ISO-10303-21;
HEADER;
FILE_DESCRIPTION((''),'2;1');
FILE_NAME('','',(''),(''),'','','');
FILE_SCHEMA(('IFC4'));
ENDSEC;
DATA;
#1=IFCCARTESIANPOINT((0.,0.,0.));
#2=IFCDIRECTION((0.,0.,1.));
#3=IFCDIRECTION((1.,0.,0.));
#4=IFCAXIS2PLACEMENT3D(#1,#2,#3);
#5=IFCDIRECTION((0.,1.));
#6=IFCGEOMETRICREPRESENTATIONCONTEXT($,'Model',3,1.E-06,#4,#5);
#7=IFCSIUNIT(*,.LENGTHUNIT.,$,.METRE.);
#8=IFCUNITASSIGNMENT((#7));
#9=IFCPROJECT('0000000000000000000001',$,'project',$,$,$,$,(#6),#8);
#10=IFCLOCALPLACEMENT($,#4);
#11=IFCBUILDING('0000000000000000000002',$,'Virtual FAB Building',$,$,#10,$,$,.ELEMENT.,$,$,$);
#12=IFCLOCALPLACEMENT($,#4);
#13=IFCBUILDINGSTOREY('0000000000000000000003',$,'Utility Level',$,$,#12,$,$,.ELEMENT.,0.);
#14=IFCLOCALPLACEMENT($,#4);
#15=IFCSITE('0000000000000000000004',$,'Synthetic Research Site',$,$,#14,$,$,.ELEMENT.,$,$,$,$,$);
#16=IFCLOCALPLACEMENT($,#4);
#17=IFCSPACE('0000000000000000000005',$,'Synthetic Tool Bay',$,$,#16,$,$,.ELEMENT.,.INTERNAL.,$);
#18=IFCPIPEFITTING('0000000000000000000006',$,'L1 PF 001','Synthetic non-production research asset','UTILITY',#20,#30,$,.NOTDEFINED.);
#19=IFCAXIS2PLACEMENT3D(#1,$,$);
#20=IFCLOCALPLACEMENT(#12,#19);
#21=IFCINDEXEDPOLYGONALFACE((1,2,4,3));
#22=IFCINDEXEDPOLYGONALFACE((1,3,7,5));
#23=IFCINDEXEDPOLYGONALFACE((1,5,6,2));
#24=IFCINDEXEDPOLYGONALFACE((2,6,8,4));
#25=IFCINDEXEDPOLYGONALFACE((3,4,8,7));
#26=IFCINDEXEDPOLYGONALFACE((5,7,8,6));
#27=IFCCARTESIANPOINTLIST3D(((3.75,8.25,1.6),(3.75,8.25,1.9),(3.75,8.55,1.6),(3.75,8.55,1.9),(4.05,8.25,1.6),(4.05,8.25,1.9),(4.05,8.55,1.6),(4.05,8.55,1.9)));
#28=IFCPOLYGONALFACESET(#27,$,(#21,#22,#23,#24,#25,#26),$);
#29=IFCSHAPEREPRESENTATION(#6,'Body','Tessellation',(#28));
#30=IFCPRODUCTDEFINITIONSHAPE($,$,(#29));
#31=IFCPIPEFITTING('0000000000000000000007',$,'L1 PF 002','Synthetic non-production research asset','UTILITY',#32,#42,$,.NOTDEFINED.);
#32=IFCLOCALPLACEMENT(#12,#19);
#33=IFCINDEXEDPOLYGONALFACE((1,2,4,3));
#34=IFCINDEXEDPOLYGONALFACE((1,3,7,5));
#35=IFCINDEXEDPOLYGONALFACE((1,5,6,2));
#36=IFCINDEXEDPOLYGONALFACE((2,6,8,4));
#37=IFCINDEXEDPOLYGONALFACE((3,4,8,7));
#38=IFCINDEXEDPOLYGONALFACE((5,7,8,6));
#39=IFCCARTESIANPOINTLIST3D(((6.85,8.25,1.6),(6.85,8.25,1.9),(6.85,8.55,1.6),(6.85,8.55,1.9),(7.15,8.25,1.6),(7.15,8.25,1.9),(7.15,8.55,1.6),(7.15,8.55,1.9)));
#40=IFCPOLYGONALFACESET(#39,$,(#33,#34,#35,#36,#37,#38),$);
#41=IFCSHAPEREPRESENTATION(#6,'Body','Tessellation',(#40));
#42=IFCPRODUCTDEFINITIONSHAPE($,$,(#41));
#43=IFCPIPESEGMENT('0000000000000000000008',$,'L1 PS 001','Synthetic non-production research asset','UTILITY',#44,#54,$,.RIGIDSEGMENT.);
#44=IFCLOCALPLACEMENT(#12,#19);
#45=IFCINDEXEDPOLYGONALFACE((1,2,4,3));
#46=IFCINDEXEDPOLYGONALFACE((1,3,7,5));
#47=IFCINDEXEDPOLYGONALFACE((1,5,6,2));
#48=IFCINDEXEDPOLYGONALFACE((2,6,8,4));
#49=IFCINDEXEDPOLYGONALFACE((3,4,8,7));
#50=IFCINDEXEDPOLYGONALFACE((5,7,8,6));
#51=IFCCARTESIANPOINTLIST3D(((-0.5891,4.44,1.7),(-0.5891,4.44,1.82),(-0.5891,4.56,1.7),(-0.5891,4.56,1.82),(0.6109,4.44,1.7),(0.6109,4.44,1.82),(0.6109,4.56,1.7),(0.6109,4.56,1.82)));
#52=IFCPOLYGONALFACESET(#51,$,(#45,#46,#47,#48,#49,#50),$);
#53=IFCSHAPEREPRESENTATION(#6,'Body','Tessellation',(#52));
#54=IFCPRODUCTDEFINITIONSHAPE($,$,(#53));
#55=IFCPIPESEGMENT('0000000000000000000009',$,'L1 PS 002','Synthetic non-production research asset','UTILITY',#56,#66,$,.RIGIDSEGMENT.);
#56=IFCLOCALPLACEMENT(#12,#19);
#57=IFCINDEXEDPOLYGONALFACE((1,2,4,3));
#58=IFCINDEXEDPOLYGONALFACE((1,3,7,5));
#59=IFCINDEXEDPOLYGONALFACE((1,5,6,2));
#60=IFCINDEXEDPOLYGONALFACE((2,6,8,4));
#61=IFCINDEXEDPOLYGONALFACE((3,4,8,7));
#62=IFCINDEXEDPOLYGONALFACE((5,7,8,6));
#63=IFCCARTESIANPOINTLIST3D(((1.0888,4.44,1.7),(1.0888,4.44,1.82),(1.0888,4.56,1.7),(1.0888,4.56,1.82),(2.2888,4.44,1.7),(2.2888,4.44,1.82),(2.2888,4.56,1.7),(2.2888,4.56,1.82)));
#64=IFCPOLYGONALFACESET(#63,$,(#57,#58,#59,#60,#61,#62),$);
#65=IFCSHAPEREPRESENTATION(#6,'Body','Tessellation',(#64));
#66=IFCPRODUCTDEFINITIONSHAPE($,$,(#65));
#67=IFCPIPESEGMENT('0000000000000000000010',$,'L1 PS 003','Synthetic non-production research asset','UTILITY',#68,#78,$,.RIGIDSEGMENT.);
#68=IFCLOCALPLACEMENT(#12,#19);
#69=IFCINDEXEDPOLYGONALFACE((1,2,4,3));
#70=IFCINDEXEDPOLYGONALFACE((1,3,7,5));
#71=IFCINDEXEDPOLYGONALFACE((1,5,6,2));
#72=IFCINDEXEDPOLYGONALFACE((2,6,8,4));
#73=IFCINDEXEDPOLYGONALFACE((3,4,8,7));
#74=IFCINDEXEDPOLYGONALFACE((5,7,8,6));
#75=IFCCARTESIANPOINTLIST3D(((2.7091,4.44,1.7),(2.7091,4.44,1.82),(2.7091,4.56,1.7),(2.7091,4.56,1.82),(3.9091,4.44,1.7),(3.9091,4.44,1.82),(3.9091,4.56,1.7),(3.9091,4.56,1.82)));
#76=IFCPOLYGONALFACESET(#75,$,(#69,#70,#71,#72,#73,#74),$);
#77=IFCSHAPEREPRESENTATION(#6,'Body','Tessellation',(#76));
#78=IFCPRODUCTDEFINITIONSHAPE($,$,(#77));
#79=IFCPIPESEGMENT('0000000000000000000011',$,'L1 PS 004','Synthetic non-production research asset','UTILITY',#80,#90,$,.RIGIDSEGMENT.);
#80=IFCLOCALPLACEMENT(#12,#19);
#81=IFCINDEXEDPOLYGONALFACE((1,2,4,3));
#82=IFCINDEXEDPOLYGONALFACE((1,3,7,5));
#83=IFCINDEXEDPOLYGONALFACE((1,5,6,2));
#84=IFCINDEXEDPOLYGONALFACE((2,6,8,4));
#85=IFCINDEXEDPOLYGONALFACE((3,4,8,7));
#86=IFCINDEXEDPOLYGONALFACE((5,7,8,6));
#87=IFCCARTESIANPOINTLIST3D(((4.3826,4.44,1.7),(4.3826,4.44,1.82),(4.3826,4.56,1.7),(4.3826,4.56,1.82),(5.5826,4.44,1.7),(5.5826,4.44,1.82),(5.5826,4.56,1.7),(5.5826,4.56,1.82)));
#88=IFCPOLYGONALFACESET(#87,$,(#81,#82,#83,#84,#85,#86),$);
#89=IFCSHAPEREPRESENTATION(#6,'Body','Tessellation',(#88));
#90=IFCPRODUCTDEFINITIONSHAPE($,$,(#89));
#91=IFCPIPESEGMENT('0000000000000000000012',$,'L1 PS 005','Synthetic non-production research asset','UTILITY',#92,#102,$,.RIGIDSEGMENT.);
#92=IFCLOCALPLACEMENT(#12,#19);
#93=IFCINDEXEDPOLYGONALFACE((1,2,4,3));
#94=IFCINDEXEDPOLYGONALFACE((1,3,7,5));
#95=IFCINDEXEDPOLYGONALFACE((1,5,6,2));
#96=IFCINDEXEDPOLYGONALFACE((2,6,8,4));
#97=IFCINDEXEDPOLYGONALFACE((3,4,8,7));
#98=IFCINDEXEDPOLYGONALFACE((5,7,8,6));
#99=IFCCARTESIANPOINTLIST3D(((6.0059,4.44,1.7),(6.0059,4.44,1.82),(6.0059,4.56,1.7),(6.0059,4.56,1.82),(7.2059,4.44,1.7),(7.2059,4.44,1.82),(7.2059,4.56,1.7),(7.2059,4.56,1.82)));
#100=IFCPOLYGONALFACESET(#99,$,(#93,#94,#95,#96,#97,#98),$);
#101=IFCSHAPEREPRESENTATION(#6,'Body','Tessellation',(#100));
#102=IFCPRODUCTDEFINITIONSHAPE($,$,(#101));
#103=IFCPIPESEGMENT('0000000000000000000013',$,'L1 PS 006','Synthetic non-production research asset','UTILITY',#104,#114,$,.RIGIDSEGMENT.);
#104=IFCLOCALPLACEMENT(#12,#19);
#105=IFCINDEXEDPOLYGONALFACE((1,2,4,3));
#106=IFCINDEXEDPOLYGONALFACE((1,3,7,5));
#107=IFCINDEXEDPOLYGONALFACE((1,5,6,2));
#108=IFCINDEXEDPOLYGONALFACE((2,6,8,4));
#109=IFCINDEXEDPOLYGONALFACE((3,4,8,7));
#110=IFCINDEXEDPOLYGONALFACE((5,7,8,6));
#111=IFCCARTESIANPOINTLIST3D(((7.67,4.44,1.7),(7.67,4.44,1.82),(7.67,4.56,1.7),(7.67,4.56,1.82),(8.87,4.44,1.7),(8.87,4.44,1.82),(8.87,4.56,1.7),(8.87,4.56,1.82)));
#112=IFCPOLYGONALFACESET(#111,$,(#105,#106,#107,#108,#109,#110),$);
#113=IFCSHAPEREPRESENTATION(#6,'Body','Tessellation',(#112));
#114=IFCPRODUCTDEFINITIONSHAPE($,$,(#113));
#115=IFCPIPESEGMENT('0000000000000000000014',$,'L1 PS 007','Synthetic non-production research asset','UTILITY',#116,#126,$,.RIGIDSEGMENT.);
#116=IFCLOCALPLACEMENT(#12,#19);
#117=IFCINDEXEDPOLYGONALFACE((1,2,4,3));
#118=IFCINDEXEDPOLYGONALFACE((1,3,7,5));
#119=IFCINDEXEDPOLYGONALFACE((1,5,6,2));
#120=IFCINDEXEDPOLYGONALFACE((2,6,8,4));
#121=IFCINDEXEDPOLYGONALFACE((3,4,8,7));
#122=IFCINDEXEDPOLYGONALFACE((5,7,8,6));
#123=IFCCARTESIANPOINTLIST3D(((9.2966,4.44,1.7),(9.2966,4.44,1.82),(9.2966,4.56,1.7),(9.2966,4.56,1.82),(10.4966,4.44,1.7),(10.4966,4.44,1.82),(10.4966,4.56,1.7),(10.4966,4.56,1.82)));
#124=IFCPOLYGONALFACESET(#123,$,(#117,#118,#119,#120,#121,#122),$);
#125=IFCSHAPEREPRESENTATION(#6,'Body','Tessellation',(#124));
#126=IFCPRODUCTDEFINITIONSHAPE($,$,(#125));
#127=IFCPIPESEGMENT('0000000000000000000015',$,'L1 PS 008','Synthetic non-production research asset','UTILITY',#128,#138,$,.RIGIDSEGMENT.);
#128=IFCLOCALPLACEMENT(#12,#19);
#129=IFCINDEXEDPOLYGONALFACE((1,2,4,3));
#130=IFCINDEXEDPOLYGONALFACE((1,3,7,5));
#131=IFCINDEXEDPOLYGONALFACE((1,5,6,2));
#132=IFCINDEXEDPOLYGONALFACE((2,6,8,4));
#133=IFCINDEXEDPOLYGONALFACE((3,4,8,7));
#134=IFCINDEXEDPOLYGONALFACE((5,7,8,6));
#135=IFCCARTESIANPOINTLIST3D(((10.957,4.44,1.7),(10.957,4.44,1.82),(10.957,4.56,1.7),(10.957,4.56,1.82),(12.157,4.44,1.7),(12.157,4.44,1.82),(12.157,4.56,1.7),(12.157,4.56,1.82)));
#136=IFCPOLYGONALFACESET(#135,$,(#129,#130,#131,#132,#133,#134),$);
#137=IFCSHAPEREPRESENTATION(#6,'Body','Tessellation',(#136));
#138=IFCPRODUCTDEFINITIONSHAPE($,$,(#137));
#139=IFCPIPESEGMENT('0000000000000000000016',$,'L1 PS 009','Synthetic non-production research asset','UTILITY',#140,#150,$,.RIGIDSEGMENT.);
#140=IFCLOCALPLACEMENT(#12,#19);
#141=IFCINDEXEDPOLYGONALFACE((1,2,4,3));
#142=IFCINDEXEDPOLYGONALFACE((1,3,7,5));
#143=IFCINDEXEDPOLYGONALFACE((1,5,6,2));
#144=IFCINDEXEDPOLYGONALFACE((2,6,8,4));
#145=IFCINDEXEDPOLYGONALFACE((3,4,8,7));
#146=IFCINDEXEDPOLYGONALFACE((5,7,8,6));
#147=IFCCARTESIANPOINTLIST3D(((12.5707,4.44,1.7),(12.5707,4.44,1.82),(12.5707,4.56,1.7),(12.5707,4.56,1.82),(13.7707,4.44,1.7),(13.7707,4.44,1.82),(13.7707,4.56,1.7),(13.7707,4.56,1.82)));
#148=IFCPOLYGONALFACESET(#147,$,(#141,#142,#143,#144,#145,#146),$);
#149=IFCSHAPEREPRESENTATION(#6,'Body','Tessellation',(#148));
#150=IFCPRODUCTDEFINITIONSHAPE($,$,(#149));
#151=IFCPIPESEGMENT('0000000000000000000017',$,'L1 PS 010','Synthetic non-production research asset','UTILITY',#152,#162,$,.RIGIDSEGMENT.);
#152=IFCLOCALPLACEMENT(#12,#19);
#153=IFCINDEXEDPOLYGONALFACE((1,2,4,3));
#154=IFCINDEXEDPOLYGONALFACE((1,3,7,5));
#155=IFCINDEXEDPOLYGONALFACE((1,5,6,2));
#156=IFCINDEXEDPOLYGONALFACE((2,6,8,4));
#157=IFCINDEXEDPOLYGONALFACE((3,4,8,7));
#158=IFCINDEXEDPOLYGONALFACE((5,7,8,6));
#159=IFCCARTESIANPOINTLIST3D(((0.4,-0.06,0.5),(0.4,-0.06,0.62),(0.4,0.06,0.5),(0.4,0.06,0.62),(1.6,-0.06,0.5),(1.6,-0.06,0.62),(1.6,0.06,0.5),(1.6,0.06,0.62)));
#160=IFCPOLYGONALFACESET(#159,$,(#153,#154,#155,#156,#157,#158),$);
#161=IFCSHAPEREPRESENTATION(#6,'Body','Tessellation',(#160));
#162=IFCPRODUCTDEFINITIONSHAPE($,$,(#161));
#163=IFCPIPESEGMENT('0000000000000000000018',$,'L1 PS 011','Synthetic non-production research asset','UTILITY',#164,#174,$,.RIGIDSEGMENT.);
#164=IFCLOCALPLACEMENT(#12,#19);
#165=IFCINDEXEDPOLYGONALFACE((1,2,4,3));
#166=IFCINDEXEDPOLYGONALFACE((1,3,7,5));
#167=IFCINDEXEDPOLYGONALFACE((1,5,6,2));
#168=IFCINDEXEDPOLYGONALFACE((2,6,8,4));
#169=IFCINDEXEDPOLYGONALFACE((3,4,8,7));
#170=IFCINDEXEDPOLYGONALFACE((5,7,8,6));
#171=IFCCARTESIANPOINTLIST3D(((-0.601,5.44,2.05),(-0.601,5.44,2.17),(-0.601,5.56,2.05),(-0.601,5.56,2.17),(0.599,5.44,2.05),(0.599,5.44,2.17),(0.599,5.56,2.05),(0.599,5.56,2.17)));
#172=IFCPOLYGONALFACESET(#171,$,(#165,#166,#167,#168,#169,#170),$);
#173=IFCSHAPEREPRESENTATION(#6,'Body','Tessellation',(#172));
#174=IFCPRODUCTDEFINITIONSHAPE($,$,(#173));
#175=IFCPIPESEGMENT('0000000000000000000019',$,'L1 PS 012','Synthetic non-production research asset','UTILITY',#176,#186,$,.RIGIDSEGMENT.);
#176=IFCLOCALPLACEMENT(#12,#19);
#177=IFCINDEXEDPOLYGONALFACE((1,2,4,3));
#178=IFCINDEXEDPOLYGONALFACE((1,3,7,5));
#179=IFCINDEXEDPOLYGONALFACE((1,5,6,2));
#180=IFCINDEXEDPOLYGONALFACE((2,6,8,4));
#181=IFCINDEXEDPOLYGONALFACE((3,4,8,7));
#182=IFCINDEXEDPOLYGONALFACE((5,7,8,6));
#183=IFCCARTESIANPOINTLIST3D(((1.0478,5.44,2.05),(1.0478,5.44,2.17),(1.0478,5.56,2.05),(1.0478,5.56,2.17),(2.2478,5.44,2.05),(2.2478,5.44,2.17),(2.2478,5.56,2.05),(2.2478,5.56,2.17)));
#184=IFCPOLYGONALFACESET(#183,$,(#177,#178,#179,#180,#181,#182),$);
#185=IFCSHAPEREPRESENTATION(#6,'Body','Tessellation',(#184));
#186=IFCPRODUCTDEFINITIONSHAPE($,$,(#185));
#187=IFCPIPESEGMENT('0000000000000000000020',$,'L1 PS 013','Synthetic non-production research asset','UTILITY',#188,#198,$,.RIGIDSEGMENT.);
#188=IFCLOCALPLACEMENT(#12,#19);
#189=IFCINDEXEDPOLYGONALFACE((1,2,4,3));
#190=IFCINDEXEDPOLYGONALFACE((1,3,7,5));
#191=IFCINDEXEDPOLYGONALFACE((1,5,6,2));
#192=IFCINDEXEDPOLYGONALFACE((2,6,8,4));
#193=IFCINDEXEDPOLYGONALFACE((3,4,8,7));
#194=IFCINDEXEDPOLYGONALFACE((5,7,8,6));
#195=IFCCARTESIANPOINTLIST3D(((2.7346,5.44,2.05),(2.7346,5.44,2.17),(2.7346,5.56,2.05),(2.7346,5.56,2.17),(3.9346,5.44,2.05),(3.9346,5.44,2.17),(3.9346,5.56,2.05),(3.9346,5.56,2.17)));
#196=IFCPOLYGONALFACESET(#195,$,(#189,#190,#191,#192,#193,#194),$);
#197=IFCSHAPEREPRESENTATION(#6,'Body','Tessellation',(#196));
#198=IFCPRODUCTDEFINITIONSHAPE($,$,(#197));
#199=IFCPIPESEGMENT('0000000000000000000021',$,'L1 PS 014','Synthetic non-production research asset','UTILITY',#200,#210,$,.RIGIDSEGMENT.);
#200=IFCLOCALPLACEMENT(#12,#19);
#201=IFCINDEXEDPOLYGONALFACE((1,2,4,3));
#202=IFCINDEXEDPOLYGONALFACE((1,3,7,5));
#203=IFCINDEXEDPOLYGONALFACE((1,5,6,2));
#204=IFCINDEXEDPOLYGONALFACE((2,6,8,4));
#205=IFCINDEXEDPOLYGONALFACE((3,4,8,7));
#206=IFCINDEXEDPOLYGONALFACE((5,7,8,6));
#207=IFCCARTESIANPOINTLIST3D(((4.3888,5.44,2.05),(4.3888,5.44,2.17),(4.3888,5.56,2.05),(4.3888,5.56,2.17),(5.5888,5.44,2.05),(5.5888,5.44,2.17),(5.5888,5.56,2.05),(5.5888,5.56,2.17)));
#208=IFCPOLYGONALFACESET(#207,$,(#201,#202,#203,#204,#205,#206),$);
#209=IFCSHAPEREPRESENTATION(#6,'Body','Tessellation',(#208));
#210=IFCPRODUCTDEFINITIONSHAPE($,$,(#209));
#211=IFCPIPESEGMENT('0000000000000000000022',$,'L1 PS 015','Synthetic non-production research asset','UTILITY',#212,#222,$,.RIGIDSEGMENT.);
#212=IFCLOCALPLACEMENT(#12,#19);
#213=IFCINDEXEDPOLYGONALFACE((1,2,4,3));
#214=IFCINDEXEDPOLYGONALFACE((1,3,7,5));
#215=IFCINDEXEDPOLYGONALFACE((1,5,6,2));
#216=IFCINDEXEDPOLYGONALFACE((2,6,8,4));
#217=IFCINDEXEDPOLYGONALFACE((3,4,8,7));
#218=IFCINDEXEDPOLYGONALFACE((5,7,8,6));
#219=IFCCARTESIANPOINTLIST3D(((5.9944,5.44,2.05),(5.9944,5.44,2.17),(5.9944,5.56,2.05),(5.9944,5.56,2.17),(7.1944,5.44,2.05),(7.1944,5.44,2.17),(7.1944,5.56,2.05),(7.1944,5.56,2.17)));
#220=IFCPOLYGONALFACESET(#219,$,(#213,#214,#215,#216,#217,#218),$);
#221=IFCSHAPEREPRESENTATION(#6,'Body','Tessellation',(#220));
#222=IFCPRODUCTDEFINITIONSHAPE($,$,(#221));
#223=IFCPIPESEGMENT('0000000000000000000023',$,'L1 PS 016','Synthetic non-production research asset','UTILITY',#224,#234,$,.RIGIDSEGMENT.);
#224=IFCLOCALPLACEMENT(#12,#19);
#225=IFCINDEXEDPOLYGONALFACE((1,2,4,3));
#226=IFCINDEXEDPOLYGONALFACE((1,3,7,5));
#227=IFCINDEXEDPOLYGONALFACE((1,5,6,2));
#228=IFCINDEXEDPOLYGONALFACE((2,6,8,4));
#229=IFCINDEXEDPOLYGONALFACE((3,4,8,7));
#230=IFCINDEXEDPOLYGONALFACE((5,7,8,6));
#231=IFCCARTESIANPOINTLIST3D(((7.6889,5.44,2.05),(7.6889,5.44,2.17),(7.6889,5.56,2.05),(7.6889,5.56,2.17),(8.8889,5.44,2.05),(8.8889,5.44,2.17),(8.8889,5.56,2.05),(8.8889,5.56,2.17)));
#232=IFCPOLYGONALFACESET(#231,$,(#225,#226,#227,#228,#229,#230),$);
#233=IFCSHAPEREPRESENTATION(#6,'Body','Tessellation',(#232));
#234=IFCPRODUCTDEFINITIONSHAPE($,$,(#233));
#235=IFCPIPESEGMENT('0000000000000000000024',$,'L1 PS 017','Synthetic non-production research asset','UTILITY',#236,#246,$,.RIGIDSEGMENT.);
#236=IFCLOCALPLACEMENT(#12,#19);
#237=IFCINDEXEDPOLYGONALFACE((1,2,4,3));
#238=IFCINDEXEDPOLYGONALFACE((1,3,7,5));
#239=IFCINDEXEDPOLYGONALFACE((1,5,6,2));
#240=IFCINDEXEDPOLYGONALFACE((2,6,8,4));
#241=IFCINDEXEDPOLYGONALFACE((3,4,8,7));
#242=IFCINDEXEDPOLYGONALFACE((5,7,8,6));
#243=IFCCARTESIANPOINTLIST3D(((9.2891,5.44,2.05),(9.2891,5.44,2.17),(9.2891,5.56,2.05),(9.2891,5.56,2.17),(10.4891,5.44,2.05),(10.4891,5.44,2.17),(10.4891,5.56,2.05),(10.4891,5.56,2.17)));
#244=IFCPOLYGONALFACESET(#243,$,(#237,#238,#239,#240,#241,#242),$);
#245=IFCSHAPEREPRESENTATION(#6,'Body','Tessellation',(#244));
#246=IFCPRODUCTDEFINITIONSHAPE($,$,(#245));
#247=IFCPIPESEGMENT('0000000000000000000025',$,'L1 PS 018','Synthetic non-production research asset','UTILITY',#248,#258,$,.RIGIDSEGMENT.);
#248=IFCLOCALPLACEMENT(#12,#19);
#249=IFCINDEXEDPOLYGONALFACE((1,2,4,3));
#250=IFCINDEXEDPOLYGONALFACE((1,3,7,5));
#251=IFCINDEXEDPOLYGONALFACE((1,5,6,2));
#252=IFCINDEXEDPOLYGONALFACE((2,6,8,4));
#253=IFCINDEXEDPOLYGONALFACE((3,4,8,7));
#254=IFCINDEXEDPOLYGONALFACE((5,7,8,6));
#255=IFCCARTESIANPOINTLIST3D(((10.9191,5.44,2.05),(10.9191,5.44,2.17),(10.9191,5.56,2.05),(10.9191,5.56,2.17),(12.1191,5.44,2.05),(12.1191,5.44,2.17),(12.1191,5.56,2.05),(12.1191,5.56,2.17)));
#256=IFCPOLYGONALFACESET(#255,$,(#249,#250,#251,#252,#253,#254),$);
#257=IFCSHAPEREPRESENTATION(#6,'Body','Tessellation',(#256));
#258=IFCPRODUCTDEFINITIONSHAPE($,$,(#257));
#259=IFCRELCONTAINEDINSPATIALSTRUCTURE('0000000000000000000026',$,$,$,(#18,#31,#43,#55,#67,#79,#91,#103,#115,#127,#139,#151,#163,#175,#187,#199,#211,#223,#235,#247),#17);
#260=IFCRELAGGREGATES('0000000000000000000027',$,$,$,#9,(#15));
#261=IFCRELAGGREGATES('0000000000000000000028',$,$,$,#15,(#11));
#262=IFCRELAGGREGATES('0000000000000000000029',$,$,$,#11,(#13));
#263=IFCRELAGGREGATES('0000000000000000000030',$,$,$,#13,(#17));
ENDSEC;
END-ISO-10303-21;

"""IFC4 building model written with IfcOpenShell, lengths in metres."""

from ifc_helpers import new_model, si_unit, direction, frame, origin_with_axes, origin_2d_with_axis, place, context, project, spatial, rectangle, extrude, element, save


model = new_model("IFC4")

# Units and contexts
model_context = context("Model", 3, precision=1e-06, world=origin_with_axes(), true_north=direction((0.0, 1.0)))
ifc_project = project(units=[si_unit("LENGTHUNIT", "METRE")], contexts=[model_context])

# Site, building, storey, space
site_placement = place(None, origin_with_axes())
site = spatial("IfcSite", under=ifc_project, at=site_placement, Name="Synthetic Research Site", CompositionType="ELEMENT")
building_placement = place(None, origin_with_axes())
building = spatial("IfcBuilding", under=site, at=building_placement, Name="Virtual FAB Building", CompositionType="ELEMENT")
storey_placement = place(None, origin_with_axes())
storey = spatial("IfcBuildingStorey", under=building, at=storey_placement, Name="Utility Level", CompositionType="ELEMENT", Elevation=0.0)
space_placement = place(None, origin_with_axes())
space = spatial("IfcSpace", under=storey, at=space_placement, Name="Synthetic Tool Bay", CompositionType="ELEMENT", PredefinedType="INTERNAL")

# Pipe fittings
for number, where, z_axis, x_axis, name in (
    (1, (3.9, 8.4, 1.6), (0.0, 0.0, 1.0), (1.0, 0.0, 0.0), "L1 PF 001"),
    (2, (7.0, 8.4, 1.6), (0.0, 0.0, 1.0), (1.0, 0.0, 0.0), "L1 PF 002"),
):
    element("IfcPipeFitting", number, at=place(None, frame(where, z_axis=z_axis, x_axis=x_axis)), inside=space, Name=name, Description="Synthetic non-production research asset", ObjectType="UTILITY", PredefinedType="NOTDEFINED", context=model_context, shape_type="SweptSolid", body=[
        extrude(rectangle(XDim=0.3, YDim=0.3, at=origin_2d_with_axis()), origin_with_axes(), (0.0, 0.0, 1.0), 0.3),
    ])

# Pipe segments
for number, where, z_axis, x_axis, name in (
    (3, (0.0109, 4.5, 1.7), (0.0, 0.0, 1.0), (1.0, 0.0, 0.0), "L1 PS 001"),
    (4, (1.6888, 4.5, 1.7), (0.0, 0.0, 1.0), (1.0, 0.0, 0.0), "L1 PS 002"),
    (5, (3.3091, 4.5, 1.7), (0.0, 0.0, 1.0), (1.0, 0.0, 0.0), "L1 PS 003"),
    (6, (4.9826, 4.5, 1.7), (0.0, 0.0, 1.0), (1.0, 0.0, 0.0), "L1 PS 004"),
    (7, (6.6059, 4.5, 1.7), (0.0, 0.0, 1.0), (1.0, 0.0, 0.0), "L1 PS 005"),
    (8, (8.27, 4.5, 1.7), (0.0, 0.0, 1.0), (1.0, 0.0, 0.0), "L1 PS 006"),
    (9, (9.8966, 4.5, 1.7), (0.0, 0.0, 1.0), (1.0, 0.0, 0.0), "L1 PS 007"),
    (10, (11.557, 4.5, 1.7), (0.0, 0.0, 1.0), (1.0, 0.0, 0.0), "L1 PS 008"),
    (11, (13.1707, 4.5, 1.7), (0.0, 0.0, 1.0), (1.0, 0.0, 0.0), "L1 PS 009"),
    (12, (1.0, 0.0, 0.5), (0.0, 0.0, 1.0), (1.0, 0.0, 0.0), "L1 PS 010"),
    (13, (-0.001, 5.5, 2.05), (0.0, 0.0, 1.0), (1.0, 0.0, 0.0), "L1 PS 011"),
    (14, (1.6478, 5.5, 2.05), (0.0, 0.0, 1.0), (1.0, 0.0, 0.0), "L1 PS 012"),
    (15, (3.3346, 5.5, 2.05), (0.0, 0.0, 1.0), (1.0, 0.0, 0.0), "L1 PS 013"),
    (16, (4.9888, 5.5, 2.05), (0.0, 0.0, 1.0), (1.0, 0.0, 0.0), "L1 PS 014"),
    (17, (6.5944, 5.5, 2.05), (0.0, 0.0, 1.0), (1.0, 0.0, 0.0), "L1 PS 015"),
    (18, (8.2889, 5.5, 2.05), (0.0, 0.0, 1.0), (1.0, 0.0, 0.0), "L1 PS 016"),
    (19, (9.8891, 5.5, 2.05), (0.0, 0.0, 1.0), (1.0, 0.0, 0.0), "L1 PS 017"),
    (20, (11.5191, 5.5, 2.05), (0.0, 0.0, 1.0), (1.0, 0.0, 0.0), "L1 PS 018"),
):
    element("IfcPipeSegment", number, at=place(None, frame(where, z_axis=z_axis, x_axis=x_axis)), inside=space, Name=name, Description="Synthetic non-production research asset", ObjectType="UTILITY", PredefinedType="RIGIDSEGMENT", context=model_context, shape_type="SweptSolid", body=[
        extrude(rectangle(XDim=1.2, YDim=0.12, at=origin_2d_with_axis()), origin_with_axes(), (0.0, 0.0, 1.0), 0.12),
    ])

save(model, "model.ifc")
